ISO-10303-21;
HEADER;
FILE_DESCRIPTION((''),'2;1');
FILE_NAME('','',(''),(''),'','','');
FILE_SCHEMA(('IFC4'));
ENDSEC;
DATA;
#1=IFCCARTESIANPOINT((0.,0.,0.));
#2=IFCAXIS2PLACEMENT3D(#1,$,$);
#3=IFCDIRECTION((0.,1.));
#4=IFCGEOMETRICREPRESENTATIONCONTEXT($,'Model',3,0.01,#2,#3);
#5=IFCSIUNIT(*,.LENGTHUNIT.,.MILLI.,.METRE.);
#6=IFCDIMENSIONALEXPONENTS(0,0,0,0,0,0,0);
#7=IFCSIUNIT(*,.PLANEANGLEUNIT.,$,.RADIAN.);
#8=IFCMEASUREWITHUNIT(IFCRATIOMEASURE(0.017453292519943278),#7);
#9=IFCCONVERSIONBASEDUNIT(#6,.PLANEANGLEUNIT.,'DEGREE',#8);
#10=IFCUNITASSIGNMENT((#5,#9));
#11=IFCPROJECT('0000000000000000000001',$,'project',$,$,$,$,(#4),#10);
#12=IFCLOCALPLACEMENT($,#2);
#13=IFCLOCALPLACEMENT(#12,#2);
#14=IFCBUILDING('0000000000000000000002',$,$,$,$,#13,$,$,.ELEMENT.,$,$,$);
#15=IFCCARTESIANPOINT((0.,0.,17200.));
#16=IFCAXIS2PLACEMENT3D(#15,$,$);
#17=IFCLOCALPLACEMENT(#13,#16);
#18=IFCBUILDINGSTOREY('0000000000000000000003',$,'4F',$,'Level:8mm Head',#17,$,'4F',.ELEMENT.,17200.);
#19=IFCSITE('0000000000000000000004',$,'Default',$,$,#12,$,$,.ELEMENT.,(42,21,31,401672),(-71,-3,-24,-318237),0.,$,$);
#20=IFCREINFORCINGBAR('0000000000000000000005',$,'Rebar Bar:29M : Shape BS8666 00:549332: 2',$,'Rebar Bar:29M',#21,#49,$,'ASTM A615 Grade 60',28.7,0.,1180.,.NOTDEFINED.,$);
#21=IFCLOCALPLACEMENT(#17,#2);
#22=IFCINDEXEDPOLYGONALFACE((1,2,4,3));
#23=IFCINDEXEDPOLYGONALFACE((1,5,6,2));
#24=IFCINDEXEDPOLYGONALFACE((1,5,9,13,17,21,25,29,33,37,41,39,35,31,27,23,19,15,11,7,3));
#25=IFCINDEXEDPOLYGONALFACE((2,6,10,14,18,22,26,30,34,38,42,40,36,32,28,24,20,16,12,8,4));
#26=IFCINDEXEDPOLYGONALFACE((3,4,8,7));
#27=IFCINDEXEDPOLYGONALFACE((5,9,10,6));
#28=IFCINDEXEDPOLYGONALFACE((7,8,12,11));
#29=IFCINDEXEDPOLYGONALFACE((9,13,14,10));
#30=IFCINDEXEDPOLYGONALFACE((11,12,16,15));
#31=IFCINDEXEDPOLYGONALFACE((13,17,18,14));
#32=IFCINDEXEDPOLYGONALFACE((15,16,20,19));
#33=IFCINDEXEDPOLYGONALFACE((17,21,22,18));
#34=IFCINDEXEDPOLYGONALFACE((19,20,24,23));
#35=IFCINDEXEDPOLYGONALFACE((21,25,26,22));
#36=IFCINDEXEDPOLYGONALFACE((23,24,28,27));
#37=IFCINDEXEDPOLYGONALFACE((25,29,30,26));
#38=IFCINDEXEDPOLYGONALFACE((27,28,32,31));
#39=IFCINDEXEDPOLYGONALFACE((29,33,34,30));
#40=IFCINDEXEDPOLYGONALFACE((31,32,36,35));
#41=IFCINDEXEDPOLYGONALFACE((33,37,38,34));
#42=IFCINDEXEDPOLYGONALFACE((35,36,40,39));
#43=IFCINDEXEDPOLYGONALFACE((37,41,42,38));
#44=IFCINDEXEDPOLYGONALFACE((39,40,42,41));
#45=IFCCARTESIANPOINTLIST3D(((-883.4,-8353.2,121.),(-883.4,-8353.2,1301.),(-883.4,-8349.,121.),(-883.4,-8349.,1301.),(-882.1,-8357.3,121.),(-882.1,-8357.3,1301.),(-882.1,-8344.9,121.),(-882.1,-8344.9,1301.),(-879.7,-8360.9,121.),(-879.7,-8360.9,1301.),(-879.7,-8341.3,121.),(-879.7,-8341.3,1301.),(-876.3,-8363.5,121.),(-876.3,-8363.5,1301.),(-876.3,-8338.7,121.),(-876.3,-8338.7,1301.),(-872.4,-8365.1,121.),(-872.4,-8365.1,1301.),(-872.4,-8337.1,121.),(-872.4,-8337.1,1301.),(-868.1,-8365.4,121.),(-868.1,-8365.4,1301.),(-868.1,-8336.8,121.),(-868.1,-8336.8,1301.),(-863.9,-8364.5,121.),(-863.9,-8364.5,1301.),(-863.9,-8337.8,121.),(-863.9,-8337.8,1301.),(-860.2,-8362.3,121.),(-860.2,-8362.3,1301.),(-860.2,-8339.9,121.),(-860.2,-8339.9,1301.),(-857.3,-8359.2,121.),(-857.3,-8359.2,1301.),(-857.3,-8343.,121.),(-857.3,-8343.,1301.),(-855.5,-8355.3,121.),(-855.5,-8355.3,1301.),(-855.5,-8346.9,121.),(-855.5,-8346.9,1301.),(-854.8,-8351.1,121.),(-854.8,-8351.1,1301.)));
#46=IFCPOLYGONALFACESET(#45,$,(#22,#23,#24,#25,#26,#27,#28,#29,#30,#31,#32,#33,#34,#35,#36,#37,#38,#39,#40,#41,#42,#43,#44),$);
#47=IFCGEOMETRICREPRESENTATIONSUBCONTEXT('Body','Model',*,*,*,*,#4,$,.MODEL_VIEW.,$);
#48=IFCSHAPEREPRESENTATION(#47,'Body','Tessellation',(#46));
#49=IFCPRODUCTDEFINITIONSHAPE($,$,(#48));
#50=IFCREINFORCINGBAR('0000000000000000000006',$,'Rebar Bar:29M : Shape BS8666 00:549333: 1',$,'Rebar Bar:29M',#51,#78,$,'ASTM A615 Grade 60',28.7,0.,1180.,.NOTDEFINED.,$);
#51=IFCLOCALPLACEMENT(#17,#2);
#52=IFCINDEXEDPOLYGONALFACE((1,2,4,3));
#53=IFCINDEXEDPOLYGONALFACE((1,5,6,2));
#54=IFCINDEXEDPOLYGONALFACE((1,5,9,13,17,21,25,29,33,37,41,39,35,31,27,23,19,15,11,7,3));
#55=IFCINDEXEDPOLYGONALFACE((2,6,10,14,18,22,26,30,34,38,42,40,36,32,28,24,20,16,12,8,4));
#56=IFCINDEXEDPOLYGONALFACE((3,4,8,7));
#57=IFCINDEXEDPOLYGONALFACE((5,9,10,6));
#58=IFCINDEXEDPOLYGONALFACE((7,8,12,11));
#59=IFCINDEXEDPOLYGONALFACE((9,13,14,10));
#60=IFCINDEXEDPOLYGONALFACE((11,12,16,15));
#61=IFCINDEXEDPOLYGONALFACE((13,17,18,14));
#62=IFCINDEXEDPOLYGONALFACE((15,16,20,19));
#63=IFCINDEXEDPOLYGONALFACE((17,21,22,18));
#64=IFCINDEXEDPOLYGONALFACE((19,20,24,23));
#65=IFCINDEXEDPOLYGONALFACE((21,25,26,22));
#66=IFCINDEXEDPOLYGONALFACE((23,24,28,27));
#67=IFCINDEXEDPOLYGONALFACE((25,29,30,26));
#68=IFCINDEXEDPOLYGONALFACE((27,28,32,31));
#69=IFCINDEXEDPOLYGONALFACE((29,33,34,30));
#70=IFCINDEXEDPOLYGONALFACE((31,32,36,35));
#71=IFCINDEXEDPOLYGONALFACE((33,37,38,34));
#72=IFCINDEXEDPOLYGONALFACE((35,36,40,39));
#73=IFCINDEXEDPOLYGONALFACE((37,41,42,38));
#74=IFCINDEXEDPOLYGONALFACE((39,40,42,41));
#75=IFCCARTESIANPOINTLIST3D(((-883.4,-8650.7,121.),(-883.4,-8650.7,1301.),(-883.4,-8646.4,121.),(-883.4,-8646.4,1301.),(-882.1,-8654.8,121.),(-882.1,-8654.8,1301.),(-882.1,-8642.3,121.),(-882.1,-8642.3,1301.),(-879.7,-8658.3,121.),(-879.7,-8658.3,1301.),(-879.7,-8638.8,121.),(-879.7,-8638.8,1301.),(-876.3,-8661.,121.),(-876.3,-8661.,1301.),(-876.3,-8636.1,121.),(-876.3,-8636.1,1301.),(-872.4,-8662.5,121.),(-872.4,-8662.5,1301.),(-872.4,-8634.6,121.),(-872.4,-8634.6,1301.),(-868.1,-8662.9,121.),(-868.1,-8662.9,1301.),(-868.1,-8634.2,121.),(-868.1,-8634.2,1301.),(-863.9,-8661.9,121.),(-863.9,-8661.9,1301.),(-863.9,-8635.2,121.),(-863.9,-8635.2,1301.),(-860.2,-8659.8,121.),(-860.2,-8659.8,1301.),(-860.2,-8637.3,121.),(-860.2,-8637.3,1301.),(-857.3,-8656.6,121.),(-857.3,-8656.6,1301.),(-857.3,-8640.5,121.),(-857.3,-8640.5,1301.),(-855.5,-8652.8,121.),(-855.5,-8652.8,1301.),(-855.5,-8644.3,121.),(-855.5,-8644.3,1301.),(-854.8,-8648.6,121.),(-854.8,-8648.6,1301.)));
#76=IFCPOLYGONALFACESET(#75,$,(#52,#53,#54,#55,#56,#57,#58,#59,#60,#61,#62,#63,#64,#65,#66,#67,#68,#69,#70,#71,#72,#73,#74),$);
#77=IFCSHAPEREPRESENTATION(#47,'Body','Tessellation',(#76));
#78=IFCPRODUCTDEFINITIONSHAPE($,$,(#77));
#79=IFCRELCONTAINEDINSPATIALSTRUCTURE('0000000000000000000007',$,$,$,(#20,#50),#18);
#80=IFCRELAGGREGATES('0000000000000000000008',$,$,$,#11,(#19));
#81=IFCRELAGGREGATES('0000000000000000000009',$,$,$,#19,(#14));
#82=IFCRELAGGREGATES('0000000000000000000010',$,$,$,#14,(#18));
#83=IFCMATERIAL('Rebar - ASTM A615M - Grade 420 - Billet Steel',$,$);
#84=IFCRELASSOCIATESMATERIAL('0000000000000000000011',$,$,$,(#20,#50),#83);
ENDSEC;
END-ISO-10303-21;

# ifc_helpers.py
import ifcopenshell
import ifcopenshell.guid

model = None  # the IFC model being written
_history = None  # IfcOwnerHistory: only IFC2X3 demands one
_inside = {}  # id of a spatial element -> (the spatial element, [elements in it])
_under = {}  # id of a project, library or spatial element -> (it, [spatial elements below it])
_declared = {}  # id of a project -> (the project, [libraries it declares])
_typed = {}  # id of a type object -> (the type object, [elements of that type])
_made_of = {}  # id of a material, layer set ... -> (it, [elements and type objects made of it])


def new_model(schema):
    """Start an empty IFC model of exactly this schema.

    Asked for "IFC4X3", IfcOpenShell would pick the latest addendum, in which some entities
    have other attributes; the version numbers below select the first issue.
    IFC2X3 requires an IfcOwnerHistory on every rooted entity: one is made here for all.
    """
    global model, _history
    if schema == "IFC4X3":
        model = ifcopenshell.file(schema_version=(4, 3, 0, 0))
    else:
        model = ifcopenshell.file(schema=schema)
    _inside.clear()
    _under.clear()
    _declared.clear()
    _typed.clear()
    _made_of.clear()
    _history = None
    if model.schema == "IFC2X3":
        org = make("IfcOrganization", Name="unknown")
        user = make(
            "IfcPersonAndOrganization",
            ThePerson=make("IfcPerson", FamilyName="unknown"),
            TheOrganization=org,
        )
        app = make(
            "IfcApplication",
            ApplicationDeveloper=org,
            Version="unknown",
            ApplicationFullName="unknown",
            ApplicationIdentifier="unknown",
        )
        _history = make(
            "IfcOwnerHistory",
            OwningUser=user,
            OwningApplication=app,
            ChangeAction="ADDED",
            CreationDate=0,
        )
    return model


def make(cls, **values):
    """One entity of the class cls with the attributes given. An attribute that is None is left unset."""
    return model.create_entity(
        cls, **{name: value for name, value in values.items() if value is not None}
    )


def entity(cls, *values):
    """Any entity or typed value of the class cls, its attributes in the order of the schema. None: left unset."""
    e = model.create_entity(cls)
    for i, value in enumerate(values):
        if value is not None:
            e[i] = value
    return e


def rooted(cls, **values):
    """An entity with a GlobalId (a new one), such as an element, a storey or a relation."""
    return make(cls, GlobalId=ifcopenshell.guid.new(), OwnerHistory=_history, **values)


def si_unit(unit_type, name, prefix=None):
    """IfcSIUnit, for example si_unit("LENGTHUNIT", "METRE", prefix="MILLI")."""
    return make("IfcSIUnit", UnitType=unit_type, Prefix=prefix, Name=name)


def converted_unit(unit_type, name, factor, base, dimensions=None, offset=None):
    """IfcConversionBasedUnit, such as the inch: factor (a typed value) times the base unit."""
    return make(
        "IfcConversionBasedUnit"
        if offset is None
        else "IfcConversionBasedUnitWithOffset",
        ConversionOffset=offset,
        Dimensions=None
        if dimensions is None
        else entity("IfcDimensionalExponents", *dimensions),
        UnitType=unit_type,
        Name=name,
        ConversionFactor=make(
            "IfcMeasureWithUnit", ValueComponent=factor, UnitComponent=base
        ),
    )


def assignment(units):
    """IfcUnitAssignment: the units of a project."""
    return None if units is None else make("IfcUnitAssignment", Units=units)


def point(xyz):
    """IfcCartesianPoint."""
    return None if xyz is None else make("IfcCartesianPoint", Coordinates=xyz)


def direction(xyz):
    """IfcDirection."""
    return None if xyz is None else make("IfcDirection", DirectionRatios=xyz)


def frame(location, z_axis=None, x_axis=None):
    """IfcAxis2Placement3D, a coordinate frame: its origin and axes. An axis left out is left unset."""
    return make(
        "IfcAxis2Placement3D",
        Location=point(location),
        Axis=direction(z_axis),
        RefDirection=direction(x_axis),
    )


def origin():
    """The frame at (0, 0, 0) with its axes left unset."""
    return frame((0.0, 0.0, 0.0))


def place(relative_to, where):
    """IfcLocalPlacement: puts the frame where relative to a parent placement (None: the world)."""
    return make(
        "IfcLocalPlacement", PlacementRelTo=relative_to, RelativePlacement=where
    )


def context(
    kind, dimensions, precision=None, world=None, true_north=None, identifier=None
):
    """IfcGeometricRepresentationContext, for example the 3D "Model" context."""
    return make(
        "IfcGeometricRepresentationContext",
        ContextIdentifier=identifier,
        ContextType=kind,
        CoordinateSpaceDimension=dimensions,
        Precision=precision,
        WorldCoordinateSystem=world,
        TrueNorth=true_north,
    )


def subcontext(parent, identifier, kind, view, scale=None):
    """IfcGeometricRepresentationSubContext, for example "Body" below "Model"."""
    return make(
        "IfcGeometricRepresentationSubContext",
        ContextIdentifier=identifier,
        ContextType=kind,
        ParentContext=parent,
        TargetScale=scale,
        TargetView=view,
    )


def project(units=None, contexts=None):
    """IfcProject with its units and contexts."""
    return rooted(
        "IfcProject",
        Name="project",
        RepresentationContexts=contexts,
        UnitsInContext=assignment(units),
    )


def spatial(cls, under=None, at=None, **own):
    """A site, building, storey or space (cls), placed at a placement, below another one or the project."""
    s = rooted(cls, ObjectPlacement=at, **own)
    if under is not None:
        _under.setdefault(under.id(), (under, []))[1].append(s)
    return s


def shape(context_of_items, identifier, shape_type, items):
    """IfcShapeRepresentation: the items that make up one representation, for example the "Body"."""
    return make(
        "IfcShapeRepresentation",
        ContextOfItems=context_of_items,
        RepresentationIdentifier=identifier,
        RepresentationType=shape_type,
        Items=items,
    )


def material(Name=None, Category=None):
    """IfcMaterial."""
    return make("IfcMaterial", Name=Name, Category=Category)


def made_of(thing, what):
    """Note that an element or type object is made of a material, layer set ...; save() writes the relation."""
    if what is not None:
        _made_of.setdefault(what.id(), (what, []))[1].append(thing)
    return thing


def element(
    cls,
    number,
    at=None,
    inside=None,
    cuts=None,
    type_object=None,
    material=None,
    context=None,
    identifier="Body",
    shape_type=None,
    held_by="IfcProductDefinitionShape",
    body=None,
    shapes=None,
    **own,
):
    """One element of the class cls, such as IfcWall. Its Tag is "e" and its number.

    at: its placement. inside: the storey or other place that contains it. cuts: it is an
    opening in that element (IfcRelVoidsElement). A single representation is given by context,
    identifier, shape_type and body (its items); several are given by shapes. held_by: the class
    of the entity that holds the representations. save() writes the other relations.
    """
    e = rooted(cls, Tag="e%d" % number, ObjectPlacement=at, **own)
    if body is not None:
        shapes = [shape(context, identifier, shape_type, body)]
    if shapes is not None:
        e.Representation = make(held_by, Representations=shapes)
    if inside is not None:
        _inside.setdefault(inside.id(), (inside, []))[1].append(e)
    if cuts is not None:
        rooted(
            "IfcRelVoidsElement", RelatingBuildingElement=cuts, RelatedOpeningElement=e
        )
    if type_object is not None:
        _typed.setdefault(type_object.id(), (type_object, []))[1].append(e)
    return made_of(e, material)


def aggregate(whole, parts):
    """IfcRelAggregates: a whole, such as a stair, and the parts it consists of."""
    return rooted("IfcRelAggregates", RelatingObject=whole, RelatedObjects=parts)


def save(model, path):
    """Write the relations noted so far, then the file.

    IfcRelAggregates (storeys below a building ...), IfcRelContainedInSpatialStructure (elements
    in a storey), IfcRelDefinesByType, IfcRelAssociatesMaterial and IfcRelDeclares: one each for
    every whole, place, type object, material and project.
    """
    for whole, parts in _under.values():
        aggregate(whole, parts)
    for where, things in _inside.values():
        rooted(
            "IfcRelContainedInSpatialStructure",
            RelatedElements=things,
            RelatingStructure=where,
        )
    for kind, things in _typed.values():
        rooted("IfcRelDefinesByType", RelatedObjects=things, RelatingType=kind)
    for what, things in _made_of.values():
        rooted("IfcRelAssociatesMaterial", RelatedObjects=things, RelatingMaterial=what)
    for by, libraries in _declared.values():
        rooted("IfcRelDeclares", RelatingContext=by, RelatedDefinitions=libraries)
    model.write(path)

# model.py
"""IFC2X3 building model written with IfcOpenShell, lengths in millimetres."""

from ifc_helpers import new_model, entity, si_unit, converted_unit, direction, frame, origin, place, context, subcontext, project, spatial, material, element, save


model = new_model("IFC2X3")

# Units and contexts
model_context = context("Model", 3, precision=0.01, world=origin(), true_north=direction((0.0, 1.0)))
body_context = subcontext(model_context, "Body", "Model", "MODEL_VIEW")
ifc_project = project(units=[si_unit("LENGTHUNIT", "METRE", prefix="MILLI"), converted_unit("PLANEANGLEUNIT", "DEGREE", entity("IfcRatioMeasure", 0.017453292519943278), si_unit("PLANEANGLEUNIT", "RADIAN"), dimensions=[0, 0, 0, 0, 0, 0, 0])], contexts=[model_context])

# Site, building, storey
site_placement = place(None, origin())
site = spatial("IfcSite", under=ifc_project, at=site_placement, Name="Default", CompositionType="ELEMENT", RefLatitude=(42, 21, 31, 401672), RefLongitude=(-71, -3, -24, -318237), RefElevation=0.0)
building_placement = place(site_placement, origin())
building = spatial("IfcBuilding", under=site, at=building_placement, CompositionType="ELEMENT")
storey_placement = place(building_placement, frame((0.0, 0.0, 17200.0)))
storey = spatial("IfcBuildingStorey", under=building, at=storey_placement, Name="4F", ObjectType="Level:8mm Head", LongName="4F", CompositionType="ELEMENT", Elevation=17200.0)

# Reinforcing bars
ifc_material_1 = material(Name="Rebar - ASTM A615M - Grade 420 - Billet Steel")
reinforcing_bar_1_placement = place(storey_placement, origin())
element("IfcReinforcingBar", 1, at=reinforcing_bar_1_placement, inside=storey, material=ifc_material_1, Name="Rebar Bar:29M : Shape BS8666 00:549332: 2", SteelGrade="ASTM A615 Grade 60", ObjectType="Rebar Bar:29M", BarLength=1180.0, BarRole="NOTDEFINED", CrossSectionArea=0.0, NominalDiameter=28.7, context=body_context, shape_type="AdvancedSweptSolid", body=[
    entity("IfcSweptDiskSolid", entity("IfcCompositeCurve", [entity("IfcCompositeCurveSegment", "CONTINUOUS", True, entity("IfcPolyline", [entity("IfcCartesianPoint", [-869.2, -8351.1, 121.0]), entity("IfcCartesianPoint", [-869.2, -8351.1, 1301.0])]))], False), 14.3, None, 0.0, 1.0),
])
reinforcing_bar_2_placement = place(storey_placement, origin())
element("IfcReinforcingBar", 2, at=reinforcing_bar_2_placement, inside=storey, material=ifc_material_1, Name="Rebar Bar:29M : Shape BS8666 00:549333: 1", SteelGrade="ASTM A615 Grade 60", ObjectType="Rebar Bar:29M", BarLength=1180.0, BarRole="NOTDEFINED", CrossSectionArea=0.0, NominalDiameter=28.7, context=body_context, shape_type="AdvancedSweptSolid", body=[
    entity("IfcSweptDiskSolid", entity("IfcCompositeCurve", [entity("IfcCompositeCurveSegment", "CONTINUOUS", True, entity("IfcPolyline", [entity("IfcCartesianPoint", [-869.2, -8648.6, 121.0]), entity("IfcCartesianPoint", [-869.2, -8648.6, 1301.0])]))], False), 14.3, None, 0.0, 1.0),
])

save(model, "model.ifc")
